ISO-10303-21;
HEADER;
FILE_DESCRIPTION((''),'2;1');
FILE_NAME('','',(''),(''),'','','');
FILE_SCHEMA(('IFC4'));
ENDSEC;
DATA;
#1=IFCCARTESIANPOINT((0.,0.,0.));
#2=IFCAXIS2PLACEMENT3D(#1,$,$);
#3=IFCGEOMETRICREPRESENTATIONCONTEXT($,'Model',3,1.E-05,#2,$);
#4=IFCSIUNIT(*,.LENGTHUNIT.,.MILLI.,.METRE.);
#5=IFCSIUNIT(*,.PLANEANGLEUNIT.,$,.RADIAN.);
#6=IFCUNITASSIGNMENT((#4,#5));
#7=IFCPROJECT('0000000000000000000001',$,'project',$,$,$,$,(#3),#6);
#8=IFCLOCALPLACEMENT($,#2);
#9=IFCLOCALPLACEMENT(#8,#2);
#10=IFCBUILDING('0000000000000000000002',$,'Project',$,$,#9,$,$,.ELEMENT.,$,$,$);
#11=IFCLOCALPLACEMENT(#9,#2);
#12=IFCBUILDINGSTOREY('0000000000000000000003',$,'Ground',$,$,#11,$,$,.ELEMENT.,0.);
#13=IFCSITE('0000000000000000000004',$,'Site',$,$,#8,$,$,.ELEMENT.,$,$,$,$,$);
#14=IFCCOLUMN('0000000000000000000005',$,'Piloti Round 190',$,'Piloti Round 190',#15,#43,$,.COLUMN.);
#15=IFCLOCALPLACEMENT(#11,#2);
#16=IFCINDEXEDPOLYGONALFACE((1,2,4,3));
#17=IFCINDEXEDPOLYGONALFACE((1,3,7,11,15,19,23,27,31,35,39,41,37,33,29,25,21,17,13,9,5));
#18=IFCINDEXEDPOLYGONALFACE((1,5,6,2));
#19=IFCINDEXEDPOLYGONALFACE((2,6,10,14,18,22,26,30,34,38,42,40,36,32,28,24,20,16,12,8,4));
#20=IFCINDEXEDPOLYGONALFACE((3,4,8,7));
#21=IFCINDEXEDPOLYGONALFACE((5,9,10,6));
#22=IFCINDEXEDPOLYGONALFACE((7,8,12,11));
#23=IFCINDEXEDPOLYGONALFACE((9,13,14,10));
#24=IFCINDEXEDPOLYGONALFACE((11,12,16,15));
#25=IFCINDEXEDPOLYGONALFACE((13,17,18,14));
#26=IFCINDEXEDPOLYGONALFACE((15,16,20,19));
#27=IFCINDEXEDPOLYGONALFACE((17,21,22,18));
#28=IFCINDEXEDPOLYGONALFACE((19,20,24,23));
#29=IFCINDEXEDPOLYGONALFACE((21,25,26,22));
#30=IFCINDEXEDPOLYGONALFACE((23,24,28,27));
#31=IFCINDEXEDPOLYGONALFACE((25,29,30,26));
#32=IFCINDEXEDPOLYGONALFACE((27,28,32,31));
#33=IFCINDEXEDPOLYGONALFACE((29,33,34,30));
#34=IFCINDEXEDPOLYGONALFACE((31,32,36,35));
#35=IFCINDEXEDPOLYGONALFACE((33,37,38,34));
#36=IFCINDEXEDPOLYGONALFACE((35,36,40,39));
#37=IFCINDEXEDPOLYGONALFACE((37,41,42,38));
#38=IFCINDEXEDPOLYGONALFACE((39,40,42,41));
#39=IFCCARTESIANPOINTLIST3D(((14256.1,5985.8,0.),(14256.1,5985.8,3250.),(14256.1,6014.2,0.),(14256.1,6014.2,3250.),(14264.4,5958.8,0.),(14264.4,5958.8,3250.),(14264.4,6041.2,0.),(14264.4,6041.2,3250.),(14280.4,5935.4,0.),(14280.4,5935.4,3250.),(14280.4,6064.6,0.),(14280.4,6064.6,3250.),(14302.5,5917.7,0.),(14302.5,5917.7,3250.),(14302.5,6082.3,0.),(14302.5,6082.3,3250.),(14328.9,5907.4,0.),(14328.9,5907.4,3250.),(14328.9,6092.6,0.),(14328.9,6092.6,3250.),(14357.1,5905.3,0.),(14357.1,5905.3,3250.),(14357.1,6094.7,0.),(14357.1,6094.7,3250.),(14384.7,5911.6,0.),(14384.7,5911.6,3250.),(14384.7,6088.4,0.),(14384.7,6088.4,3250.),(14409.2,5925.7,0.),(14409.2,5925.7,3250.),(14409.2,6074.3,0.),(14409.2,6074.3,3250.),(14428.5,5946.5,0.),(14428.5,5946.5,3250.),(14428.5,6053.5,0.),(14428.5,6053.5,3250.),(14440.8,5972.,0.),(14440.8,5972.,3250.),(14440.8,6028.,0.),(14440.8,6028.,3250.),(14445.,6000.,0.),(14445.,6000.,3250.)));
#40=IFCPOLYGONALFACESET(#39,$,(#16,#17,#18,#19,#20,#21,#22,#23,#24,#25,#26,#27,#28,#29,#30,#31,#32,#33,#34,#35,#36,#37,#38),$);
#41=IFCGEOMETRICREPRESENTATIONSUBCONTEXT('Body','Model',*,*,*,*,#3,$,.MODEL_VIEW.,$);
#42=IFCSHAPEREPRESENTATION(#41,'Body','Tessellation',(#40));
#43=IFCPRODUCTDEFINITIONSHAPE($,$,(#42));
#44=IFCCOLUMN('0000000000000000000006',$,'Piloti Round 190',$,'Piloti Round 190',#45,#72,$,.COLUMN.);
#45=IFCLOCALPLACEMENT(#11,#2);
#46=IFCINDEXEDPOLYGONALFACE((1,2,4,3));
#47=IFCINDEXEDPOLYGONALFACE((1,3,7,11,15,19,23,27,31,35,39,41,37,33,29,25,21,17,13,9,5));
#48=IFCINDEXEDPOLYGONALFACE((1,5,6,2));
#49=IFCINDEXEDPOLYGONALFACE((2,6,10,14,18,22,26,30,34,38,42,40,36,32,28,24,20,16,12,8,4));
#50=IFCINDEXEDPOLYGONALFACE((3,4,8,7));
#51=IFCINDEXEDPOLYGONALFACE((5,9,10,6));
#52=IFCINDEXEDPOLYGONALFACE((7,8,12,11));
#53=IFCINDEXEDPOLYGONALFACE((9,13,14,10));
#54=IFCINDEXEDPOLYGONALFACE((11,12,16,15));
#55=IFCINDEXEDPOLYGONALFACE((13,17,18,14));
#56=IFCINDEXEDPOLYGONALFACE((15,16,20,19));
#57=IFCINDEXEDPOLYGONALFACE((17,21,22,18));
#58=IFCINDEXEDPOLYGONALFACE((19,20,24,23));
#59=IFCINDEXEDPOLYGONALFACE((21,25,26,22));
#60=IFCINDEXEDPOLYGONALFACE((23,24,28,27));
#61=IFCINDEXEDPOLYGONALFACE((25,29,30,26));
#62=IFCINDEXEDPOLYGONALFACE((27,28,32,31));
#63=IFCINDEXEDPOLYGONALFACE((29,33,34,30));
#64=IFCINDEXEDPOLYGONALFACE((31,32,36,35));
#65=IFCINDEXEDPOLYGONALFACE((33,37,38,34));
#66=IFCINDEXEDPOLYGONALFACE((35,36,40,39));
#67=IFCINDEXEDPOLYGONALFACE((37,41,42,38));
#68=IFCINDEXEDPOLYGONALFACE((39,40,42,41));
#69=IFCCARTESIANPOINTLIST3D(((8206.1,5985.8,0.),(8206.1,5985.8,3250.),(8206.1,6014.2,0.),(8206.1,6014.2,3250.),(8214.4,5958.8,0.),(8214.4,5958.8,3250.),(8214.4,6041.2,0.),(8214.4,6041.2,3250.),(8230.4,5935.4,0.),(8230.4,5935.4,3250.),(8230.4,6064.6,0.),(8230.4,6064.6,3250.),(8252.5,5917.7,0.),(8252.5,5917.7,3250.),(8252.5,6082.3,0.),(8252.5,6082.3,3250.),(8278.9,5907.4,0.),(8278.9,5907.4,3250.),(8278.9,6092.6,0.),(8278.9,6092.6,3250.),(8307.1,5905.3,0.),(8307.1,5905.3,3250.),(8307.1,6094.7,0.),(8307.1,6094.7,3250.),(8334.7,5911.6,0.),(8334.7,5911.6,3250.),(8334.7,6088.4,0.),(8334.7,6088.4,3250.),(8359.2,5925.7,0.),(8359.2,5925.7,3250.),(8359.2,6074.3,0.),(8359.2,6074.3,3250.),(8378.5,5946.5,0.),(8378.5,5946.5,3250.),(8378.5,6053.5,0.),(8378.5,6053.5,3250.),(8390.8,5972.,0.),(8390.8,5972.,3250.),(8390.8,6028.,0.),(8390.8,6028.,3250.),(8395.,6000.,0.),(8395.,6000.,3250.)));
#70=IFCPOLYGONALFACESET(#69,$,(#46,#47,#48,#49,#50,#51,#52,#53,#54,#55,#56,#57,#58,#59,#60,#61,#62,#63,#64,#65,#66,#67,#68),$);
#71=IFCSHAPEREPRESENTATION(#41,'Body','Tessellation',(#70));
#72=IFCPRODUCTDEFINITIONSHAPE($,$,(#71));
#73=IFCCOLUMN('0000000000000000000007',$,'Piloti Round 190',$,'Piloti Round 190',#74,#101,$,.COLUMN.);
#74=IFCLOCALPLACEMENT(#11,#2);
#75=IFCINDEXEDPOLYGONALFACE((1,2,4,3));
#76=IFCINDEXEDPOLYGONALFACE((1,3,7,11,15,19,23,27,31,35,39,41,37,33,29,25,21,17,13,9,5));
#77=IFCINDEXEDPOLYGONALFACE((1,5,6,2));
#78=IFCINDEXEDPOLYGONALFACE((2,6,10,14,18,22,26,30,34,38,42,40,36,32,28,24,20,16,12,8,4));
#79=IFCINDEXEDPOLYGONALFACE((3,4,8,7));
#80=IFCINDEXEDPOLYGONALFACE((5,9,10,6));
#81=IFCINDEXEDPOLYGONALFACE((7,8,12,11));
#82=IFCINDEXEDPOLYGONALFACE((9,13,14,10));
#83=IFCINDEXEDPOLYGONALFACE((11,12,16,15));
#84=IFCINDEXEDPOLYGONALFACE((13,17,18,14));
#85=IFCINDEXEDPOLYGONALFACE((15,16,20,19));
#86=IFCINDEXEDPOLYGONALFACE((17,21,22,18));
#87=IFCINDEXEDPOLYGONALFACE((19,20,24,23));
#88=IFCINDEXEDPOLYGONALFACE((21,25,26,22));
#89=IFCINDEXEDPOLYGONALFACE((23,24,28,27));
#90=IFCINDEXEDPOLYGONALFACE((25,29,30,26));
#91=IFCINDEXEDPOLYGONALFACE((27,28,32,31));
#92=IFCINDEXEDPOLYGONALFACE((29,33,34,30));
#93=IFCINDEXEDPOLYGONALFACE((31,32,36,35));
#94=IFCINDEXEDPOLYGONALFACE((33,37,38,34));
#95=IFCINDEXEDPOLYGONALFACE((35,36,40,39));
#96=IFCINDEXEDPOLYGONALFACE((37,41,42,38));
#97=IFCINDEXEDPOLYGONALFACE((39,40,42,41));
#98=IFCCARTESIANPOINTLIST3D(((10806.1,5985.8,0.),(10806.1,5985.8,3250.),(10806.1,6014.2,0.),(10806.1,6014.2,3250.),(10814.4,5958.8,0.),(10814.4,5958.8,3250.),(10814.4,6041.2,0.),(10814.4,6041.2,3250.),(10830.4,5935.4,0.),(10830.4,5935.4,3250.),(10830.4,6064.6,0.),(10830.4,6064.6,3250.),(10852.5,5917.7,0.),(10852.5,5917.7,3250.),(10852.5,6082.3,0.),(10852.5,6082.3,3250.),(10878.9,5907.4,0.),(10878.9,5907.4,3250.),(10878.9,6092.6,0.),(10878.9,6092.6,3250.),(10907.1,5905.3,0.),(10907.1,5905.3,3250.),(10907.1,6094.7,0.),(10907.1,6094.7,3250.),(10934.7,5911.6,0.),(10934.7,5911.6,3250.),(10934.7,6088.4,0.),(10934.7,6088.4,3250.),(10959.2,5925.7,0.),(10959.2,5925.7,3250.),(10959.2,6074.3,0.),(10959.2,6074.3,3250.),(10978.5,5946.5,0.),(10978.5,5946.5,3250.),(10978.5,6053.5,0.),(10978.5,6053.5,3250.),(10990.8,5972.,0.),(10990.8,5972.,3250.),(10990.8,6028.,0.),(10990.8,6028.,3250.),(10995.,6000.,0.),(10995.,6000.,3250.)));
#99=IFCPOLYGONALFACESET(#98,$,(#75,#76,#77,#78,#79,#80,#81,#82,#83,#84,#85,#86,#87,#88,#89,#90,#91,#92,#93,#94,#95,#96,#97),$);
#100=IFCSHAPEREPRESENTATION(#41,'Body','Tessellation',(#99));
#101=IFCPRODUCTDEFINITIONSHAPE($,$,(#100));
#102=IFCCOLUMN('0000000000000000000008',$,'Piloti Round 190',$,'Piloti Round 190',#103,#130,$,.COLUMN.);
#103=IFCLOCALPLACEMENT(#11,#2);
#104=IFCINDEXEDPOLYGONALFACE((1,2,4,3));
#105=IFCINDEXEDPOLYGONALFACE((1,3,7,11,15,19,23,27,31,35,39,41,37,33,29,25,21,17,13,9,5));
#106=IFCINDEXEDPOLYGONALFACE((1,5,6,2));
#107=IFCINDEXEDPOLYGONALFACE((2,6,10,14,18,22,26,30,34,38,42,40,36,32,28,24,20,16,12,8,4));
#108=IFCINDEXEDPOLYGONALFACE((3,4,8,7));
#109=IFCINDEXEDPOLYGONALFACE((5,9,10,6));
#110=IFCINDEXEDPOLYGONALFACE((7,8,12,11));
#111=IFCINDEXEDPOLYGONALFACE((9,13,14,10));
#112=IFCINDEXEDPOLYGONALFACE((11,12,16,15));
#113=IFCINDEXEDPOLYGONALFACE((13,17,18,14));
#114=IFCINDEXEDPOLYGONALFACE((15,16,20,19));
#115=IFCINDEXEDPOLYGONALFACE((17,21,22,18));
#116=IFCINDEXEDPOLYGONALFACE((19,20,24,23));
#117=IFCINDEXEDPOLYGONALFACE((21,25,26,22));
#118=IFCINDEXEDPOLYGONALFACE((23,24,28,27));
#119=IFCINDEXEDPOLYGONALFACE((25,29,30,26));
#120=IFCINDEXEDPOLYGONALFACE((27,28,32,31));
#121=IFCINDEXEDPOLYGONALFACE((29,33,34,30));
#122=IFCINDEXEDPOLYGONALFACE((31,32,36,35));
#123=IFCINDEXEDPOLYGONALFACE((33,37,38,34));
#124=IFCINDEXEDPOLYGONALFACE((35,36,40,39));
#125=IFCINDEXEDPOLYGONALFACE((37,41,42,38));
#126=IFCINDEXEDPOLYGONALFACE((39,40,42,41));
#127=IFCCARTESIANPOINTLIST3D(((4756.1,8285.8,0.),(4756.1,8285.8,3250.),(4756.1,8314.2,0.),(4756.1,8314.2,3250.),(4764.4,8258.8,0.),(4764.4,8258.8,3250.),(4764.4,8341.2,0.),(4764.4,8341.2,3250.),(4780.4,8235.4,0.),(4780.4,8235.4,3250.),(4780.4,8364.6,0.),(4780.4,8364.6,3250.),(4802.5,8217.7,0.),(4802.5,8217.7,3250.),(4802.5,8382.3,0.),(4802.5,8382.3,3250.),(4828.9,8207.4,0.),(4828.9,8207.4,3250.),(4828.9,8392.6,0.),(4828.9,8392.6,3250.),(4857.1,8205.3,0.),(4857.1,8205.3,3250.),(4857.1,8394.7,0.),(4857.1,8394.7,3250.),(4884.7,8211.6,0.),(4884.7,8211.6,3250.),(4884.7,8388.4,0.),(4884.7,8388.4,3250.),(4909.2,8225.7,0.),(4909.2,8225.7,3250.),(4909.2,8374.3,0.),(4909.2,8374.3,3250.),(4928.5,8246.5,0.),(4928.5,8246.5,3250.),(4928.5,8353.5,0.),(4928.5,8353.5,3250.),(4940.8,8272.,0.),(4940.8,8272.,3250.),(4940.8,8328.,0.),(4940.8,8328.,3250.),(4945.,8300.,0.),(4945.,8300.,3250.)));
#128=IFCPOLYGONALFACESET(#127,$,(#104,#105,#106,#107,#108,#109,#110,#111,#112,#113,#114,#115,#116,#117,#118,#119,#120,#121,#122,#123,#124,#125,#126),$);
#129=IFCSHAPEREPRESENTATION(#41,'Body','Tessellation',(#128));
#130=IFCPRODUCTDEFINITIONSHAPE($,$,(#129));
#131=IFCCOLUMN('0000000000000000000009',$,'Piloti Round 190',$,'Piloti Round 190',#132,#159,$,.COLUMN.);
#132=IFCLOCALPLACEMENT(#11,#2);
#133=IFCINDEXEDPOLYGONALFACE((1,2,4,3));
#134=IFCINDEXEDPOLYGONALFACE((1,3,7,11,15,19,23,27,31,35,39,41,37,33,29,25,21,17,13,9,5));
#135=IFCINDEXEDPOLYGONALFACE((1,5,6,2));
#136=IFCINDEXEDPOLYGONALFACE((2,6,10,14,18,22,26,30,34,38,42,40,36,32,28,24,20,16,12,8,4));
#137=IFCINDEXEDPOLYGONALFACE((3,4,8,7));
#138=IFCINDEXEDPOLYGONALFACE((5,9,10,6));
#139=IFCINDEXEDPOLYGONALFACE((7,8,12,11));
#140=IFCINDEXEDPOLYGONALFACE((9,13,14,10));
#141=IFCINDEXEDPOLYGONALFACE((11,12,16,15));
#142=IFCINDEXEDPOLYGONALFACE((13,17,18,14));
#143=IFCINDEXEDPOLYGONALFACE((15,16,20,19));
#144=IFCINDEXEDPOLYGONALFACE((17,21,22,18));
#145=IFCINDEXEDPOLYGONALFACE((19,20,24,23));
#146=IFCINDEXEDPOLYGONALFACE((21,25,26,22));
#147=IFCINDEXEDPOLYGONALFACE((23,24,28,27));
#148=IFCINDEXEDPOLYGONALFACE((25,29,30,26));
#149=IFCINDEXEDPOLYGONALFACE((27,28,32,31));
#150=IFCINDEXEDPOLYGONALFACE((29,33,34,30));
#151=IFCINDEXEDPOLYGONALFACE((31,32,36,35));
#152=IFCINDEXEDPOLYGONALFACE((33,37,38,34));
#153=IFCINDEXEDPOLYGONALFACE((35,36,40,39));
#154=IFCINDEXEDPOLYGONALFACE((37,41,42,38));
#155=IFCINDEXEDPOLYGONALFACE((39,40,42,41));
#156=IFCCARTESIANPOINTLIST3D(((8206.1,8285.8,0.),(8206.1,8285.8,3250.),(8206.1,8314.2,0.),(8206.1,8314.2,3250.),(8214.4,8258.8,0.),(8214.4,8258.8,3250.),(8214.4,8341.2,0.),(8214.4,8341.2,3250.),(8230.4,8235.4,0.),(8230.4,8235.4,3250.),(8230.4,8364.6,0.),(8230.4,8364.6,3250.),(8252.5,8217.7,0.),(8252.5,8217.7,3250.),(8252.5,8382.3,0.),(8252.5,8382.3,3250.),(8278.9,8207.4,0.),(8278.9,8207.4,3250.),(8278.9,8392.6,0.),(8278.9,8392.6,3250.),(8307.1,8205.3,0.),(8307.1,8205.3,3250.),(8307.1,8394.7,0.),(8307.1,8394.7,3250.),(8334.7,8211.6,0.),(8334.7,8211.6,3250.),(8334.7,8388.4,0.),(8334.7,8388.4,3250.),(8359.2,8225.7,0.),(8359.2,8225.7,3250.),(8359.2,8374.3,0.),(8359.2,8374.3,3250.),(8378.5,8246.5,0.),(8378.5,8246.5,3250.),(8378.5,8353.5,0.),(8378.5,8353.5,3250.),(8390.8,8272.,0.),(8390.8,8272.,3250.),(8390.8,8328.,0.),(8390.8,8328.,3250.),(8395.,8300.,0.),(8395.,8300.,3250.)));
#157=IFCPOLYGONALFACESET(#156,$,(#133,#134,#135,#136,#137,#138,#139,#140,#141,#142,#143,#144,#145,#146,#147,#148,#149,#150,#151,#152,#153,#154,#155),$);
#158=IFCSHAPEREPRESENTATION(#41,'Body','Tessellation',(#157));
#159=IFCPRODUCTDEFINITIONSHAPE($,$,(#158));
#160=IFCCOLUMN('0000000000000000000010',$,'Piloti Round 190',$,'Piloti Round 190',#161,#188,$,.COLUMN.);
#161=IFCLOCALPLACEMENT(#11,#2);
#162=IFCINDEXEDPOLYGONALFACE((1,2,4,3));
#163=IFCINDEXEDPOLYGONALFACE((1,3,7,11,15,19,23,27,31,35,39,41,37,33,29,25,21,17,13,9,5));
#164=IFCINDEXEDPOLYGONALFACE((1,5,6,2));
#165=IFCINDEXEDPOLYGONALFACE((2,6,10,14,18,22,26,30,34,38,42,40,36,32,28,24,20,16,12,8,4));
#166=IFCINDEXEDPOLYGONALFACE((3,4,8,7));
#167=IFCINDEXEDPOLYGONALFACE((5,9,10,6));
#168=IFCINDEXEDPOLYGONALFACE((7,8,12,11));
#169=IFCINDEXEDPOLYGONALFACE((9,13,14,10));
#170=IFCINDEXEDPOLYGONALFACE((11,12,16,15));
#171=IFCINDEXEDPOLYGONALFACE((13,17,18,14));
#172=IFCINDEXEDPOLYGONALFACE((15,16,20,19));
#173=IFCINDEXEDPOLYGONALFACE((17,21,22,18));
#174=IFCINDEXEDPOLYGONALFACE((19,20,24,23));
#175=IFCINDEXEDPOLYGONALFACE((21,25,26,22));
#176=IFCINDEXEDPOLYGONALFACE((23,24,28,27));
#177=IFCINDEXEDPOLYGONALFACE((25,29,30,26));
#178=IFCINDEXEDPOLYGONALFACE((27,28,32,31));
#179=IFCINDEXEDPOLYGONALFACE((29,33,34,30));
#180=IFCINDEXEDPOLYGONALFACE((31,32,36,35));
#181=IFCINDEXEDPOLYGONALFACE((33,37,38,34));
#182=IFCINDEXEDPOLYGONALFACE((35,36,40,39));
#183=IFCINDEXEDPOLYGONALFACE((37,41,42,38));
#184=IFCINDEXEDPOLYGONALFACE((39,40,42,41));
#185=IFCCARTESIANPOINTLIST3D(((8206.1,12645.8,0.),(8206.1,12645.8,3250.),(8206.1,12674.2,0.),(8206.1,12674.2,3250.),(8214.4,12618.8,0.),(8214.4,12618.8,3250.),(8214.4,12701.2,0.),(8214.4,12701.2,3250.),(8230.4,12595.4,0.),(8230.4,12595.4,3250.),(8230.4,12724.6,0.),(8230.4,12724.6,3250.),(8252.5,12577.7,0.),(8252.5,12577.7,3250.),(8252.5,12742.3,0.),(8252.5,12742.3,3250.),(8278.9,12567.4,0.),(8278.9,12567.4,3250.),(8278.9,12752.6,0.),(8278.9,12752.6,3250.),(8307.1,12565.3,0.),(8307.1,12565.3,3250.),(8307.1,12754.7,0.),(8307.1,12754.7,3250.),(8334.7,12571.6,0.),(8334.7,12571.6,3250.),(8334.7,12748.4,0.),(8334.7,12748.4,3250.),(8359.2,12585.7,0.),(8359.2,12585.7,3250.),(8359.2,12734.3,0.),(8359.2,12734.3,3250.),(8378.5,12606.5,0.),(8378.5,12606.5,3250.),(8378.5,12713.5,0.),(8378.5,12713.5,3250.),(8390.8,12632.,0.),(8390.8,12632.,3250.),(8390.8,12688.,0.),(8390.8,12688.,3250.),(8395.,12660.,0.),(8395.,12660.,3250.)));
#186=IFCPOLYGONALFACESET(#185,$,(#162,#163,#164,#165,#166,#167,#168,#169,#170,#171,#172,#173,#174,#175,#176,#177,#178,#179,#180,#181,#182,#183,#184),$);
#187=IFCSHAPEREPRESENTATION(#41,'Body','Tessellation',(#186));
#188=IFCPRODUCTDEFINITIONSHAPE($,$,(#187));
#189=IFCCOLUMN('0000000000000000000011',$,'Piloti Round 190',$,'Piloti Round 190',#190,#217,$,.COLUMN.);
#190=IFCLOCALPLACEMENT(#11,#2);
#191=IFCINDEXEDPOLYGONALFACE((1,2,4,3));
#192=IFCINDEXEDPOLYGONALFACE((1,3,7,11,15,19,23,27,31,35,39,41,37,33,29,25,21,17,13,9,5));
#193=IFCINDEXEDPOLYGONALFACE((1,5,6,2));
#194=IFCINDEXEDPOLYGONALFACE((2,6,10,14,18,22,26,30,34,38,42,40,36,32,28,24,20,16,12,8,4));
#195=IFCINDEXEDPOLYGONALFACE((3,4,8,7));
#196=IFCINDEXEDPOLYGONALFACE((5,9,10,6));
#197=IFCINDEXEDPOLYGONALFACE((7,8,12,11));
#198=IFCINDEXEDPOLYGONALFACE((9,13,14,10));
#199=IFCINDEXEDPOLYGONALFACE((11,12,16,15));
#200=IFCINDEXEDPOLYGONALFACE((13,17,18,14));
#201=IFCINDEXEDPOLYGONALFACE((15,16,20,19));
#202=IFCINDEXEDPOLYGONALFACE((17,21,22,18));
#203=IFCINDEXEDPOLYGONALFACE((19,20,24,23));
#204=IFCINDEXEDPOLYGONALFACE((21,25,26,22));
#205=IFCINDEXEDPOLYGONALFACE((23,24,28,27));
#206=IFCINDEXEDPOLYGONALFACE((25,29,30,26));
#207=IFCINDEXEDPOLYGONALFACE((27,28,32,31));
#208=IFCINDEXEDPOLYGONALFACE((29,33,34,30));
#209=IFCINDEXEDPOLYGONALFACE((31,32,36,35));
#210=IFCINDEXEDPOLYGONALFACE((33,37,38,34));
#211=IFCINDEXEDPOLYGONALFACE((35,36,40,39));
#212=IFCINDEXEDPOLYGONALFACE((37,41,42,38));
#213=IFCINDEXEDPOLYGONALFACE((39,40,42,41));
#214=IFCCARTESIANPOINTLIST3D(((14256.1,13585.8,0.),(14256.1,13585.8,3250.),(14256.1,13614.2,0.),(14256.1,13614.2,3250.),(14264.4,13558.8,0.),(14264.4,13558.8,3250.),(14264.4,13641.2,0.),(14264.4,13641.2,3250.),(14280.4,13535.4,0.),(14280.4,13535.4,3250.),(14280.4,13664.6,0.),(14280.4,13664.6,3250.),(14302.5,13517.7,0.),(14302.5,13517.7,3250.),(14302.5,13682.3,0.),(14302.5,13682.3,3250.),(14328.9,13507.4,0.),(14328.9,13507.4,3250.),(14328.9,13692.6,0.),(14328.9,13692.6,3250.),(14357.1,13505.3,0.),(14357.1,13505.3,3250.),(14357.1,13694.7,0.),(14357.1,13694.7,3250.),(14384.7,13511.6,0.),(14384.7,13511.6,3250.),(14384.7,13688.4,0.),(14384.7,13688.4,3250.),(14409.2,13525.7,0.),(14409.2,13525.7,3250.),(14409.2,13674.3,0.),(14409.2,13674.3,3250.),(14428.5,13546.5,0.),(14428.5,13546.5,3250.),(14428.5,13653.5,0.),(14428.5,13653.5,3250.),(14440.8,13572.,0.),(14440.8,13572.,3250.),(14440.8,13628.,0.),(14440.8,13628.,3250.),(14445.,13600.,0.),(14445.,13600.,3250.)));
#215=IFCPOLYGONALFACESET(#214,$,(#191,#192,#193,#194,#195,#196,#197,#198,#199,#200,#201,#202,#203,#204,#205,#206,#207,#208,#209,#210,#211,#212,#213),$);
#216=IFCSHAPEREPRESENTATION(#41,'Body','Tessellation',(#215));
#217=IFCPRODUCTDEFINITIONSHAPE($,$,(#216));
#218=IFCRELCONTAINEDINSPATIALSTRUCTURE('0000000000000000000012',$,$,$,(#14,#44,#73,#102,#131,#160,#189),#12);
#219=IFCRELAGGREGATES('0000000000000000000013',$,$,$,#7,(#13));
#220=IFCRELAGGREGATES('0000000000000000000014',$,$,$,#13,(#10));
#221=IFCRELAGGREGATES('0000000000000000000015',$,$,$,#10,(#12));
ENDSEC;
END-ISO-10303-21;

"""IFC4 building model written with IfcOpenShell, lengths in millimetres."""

from ifc_helpers import new_model, si_unit, frame, origin, origin_2d, place, context, subcontext, project, spatial, circle, extrude, element, save


model = new_model("IFC4")

# Units and contexts
model_context = context("Model", 3, precision=1e-05, world=origin())
body_context = subcontext(model_context, "Body", "Model", "MODEL_VIEW")
ifc_project = project(units=[si_unit("LENGTHUNIT", "METRE", prefix="MILLI"), si_unit("PLANEANGLEUNIT", "RADIAN")], contexts=[model_context])

# Site, building, storey
site_placement = place(None, origin())
site = spatial("IfcSite", under=ifc_project, at=site_placement, Name="Site", CompositionType="ELEMENT")
building_placement = place(site_placement, origin())
building = spatial("IfcBuilding", under=site, at=building_placement, Name="Project", CompositionType="ELEMENT")
storey_placement = place(building_placement, origin())
storey = spatial("IfcBuildingStorey", under=building, at=storey_placement, Name="Ground", CompositionType="ELEMENT", Elevation=0.0)

# Columns
for number, where, z_axis, x_axis, name in (
    (1, (14350.0, 6000.0, 0.0), (0.0, 0.0, 1.0), (1.0, 0.0, 0.0), "Piloti Round 190"),
    (2, (8300.0, 6000.0, 0.0), (0.0, 0.0, 1.0), (1.0, 0.0, 0.0), "Piloti Round 190"),
    (3, (10900.0, 6000.0, 0.0), (0.0, 0.0, 1.0), (1.0, 0.0, 0.0), "Piloti Round 190"),
    (4, (4850.0, 8300.0, 0.0), (0.0, 0.0, 1.0), (1.0, 0.0, 0.0), "Piloti Round 190"),
    (5, (8300.0, 8300.0, 0.0), (0.0, 0.0, 1.0), (1.0, 0.0, 0.0), "Piloti Round 190"),
    (6, (8300.0, 12660.0, 0.0), (0.0, 0.0, 1.0), (1.0, 0.0, 0.0), "Piloti Round 190"),
    (7, (14350.0, 13600.0, 0.0), (0.0, 0.0, 1.0), (1.0, 0.0, 0.0), "Piloti Round 190"),
):
    element("IfcColumn", number, at=place(storey_placement, frame(where, z_axis=z_axis, x_axis=x_axis)), inside=storey, Name=name, ObjectType="Piloti Round 190", PredefinedType="COLUMN", context=body_context, shape_type="SweptSolid", body=[
        extrude(circle(Radius=95.0, at=origin_2d()), origin(), (0.0, 0.0, 1.0), 3250.0),
    ])

save(model, "model.ifc")
